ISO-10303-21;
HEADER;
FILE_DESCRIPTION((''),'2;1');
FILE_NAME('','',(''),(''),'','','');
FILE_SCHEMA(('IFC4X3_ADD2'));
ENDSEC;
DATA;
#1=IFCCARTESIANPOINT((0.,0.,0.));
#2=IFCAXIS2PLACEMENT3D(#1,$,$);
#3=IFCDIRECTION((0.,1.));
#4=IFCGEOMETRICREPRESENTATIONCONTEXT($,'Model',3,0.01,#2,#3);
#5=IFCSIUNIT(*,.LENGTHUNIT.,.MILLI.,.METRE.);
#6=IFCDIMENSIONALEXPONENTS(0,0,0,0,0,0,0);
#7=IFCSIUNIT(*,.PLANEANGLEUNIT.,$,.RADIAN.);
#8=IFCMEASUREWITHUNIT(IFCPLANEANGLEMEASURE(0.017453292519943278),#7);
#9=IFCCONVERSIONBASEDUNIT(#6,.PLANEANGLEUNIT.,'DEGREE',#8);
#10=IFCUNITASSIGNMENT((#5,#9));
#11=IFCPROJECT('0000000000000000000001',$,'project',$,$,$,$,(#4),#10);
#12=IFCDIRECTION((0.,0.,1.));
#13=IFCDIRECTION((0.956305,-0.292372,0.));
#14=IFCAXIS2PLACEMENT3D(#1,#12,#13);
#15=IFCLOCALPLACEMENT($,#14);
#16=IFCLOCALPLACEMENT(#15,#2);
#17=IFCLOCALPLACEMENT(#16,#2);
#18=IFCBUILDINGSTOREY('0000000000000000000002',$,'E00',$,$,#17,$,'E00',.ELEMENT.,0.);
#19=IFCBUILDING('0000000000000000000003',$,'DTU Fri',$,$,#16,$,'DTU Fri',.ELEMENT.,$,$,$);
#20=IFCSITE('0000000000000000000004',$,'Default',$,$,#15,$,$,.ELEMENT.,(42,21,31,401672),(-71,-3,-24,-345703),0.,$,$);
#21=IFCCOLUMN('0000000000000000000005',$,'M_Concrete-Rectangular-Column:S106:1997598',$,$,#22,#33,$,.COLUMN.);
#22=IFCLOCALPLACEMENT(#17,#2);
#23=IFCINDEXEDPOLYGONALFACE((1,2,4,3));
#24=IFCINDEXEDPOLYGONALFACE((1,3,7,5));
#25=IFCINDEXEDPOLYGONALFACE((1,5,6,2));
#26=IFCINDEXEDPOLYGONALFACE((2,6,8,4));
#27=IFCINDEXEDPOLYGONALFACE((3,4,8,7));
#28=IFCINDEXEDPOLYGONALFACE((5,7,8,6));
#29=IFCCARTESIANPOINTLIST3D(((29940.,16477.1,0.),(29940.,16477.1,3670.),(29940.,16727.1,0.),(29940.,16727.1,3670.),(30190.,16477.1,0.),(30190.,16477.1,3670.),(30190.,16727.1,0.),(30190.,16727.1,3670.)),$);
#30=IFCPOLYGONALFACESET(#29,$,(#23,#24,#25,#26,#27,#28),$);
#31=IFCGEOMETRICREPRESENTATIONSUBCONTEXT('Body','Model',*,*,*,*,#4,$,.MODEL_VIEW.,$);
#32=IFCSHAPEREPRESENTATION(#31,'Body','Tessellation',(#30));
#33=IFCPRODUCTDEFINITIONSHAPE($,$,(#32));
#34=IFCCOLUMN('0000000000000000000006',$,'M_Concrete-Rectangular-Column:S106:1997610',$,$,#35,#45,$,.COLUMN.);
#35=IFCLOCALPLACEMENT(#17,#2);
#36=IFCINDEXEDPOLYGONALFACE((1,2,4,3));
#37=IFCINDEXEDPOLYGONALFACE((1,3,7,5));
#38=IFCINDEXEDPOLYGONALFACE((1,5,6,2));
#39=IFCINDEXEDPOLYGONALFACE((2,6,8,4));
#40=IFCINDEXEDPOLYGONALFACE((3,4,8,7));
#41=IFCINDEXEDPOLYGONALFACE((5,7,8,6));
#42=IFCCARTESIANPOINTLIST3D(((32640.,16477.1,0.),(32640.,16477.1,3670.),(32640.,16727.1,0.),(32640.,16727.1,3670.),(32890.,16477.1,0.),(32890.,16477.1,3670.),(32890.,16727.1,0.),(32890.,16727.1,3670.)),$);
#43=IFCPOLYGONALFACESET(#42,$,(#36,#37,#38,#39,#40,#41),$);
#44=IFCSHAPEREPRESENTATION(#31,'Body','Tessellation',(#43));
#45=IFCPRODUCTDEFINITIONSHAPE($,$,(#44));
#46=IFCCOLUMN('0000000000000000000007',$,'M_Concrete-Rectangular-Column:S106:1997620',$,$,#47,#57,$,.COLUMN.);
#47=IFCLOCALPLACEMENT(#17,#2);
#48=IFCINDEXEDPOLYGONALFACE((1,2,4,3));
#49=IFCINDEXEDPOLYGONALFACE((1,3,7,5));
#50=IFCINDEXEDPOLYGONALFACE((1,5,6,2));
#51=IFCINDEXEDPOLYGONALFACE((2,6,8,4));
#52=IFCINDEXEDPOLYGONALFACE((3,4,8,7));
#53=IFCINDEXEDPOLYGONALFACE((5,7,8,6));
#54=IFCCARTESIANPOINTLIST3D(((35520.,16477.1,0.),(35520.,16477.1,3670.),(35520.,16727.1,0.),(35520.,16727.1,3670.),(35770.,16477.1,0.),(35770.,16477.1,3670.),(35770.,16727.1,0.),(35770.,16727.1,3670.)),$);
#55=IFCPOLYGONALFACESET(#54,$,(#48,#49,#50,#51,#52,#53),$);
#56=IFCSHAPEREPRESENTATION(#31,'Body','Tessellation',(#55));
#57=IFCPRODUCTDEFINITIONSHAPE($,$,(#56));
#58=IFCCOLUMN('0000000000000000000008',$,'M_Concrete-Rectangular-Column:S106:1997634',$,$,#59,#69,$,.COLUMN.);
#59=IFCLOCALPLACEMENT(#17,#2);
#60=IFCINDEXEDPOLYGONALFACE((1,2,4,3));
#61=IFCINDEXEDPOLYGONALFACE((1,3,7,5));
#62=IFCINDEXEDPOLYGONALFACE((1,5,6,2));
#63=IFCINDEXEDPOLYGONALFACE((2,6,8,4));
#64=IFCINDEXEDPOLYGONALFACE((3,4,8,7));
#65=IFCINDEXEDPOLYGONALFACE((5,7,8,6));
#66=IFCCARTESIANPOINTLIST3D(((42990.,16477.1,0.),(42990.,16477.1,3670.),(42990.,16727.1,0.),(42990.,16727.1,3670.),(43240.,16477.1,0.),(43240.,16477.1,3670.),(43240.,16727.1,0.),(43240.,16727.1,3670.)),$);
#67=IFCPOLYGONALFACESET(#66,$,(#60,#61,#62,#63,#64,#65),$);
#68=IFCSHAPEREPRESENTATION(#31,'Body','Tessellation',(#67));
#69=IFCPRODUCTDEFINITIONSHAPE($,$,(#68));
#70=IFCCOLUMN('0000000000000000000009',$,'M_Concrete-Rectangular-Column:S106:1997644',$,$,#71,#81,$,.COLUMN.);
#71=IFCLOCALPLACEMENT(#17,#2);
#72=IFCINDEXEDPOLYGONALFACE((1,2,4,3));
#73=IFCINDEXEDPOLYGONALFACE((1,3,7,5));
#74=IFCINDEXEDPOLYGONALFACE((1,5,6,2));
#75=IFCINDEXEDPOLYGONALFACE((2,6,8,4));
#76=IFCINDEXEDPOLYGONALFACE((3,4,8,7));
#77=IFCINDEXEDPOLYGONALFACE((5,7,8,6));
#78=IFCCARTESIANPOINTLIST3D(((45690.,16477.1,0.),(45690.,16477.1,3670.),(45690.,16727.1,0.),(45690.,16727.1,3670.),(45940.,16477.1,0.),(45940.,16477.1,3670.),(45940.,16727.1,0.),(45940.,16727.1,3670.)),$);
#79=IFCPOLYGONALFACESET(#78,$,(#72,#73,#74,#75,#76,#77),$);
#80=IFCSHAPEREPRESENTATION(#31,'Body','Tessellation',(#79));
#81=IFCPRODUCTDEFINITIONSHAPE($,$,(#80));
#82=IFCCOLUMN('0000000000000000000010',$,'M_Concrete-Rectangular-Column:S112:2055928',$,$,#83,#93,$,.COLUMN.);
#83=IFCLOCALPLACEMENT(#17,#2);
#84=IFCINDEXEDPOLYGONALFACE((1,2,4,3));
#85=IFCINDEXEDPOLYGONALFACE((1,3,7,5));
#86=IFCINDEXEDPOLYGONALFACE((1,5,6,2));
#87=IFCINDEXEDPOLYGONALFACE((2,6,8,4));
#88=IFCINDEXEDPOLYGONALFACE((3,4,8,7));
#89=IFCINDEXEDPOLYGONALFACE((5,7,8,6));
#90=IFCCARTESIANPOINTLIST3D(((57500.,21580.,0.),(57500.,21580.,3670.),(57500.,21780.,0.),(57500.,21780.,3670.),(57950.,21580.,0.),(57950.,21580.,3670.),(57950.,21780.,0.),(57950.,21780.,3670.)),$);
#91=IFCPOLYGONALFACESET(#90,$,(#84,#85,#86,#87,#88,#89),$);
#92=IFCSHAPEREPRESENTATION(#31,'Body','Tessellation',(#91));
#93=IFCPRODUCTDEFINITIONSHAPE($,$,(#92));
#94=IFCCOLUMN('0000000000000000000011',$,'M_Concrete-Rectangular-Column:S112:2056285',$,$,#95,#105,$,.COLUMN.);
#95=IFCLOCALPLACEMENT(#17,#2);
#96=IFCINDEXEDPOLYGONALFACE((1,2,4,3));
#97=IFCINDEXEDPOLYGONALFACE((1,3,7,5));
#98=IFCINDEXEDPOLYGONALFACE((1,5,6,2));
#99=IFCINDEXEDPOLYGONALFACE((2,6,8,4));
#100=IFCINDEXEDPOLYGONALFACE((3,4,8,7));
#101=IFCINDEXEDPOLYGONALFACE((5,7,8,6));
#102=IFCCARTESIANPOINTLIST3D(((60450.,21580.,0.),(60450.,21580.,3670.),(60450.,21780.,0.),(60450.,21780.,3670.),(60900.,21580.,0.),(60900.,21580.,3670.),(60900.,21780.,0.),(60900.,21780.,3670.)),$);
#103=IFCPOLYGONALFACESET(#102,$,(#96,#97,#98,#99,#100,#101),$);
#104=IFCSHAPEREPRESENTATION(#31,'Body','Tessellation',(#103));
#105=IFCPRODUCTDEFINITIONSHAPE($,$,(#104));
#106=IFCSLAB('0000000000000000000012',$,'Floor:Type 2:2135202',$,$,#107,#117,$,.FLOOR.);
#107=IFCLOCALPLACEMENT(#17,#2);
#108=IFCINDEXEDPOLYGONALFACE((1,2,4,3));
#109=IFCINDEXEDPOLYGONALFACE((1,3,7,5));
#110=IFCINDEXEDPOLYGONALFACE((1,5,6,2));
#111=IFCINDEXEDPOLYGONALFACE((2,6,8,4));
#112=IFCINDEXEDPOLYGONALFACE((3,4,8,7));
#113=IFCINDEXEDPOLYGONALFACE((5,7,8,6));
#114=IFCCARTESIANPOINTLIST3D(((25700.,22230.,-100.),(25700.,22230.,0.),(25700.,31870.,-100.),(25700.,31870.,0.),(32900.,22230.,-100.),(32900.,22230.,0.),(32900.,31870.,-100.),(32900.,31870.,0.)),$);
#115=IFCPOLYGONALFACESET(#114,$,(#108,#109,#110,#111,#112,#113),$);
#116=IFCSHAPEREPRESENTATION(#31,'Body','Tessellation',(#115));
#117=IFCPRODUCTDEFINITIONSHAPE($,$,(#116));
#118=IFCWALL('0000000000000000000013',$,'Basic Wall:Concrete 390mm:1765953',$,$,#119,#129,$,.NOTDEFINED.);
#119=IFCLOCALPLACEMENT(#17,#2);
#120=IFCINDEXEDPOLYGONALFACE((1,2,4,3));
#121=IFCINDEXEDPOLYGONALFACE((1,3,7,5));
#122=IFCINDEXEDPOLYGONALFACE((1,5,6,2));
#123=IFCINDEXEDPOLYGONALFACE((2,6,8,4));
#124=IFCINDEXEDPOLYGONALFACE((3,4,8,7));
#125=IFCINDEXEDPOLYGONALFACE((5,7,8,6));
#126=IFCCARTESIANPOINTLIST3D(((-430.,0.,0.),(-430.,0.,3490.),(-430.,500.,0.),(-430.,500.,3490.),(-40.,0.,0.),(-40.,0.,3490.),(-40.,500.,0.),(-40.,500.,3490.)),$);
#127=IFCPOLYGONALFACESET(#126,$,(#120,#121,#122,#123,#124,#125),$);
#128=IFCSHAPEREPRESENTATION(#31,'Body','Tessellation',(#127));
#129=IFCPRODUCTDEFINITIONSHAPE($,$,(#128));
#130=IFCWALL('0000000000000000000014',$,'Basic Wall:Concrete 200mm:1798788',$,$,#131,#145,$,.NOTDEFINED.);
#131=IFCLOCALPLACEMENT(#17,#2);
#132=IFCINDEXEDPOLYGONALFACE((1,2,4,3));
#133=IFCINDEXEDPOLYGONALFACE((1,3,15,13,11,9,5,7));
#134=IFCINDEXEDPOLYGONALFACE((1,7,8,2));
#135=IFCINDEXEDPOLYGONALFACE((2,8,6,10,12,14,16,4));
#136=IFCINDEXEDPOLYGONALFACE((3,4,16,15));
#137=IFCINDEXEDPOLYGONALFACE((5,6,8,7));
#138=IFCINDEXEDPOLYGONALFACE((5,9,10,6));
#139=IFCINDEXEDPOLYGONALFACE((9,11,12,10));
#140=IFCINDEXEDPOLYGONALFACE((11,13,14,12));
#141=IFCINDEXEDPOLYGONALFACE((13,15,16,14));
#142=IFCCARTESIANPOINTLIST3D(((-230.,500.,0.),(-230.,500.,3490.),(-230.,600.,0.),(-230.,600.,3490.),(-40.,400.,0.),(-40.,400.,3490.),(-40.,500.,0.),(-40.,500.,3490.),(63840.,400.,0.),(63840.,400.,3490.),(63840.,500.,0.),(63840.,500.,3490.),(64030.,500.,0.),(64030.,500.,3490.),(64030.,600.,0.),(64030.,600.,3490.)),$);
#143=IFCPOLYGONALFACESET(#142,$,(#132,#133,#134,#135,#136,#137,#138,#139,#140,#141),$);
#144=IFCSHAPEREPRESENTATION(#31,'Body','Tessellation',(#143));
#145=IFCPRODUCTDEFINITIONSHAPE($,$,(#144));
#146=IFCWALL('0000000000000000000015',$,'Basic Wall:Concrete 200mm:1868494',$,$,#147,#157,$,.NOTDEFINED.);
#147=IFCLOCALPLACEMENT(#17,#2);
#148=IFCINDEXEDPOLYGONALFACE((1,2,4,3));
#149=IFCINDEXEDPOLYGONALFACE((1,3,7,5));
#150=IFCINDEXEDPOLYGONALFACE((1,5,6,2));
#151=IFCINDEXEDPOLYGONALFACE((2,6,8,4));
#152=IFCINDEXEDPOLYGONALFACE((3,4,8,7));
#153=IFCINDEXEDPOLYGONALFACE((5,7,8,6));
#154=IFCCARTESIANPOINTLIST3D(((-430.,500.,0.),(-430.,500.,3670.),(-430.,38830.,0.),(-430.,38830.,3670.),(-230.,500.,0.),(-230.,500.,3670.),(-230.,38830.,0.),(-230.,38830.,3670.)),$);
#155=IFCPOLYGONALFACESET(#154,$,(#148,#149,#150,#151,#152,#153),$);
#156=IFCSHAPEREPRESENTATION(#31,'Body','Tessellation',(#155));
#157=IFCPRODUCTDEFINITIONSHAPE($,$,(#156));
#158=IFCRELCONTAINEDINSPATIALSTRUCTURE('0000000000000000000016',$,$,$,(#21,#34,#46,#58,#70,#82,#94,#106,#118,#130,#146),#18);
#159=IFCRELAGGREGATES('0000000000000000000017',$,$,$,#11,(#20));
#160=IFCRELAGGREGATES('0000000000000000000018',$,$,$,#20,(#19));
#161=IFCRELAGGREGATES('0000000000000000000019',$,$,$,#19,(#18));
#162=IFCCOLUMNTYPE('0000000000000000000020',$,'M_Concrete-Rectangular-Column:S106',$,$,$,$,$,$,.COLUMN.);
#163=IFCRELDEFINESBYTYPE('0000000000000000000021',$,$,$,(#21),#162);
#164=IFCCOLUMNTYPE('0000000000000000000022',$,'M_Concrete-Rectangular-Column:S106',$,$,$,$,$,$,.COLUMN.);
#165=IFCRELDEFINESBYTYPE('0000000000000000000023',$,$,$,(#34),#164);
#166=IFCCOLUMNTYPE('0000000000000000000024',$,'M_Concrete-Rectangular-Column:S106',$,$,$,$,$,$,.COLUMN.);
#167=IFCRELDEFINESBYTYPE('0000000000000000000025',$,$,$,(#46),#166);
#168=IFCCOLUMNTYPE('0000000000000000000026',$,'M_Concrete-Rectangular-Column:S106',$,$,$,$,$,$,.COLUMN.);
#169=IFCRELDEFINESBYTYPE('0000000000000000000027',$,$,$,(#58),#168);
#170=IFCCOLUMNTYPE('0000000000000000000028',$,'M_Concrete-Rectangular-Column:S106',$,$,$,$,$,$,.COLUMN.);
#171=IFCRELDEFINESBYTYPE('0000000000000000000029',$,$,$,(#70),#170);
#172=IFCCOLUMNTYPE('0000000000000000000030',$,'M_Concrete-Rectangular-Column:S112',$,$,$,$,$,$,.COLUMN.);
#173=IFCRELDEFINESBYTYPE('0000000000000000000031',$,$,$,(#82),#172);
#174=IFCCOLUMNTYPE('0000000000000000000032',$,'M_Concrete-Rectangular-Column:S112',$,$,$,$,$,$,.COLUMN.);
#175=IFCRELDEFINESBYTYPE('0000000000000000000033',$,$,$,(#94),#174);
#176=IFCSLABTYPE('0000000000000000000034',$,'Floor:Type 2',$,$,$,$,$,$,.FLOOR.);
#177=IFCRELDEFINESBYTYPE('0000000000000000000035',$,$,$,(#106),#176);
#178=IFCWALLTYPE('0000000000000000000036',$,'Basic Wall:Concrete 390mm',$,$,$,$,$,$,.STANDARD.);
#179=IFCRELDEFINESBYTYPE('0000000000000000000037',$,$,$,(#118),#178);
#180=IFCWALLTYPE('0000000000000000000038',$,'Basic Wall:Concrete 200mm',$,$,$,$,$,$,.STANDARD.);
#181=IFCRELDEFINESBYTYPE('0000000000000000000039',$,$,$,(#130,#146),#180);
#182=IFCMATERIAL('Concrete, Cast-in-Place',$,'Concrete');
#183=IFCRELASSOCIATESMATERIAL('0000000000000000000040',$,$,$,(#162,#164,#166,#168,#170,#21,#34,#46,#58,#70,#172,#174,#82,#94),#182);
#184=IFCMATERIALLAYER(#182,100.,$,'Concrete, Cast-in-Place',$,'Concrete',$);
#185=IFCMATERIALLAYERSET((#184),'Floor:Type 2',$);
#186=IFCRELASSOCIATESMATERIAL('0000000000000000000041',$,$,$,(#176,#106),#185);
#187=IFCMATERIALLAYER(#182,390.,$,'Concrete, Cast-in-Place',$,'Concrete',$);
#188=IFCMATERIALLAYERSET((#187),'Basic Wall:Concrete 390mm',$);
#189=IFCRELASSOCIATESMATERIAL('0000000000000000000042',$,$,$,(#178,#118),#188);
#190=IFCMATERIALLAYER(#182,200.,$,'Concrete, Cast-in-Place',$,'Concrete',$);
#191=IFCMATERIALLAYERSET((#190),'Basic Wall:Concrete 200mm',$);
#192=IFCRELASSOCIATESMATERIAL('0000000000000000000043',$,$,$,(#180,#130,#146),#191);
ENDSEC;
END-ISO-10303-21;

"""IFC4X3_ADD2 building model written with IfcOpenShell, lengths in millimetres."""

from ifc_helpers import new_model, entity, si_unit, converted_unit, direction, frame, frame_2d, origin, origin_2d_with_axis, place, context, subcontext, project, spatial, polyline, rectangle, outline, extrude, source, transform, mapped, material, layer, layer_set, layer_usage, material_profile, profile_set, profile_usage, type_object, type_shapes, element, save


model = new_model("IFC4X3_ADD2")

# Units and contexts
model_context = context("Model", 3, precision=0.01, world=origin(), true_north=direction((0.0, 1.0)))
body_context = subcontext(model_context, "Body", "Model", "MODEL_VIEW")
ifc_project = project(units=[si_unit("LENGTHUNIT", "METRE", prefix="MILLI"), converted_unit("PLANEANGLEUNIT", "DEGREE", entity("IfcPlaneAngleMeasure", 0.017453292519943278), si_unit("PLANEANGLEUNIT", "RADIAN"), dimensions=[0, 0, 0, 0, 0, 0, 0])], contexts=[model_context])

# Site, building, storey
site_placement = place(None, frame((0.0, 0.0, 0.0), z_axis=(0.0, 0.0, 1.0), x_axis=(0.956305, -0.292372, 0.0)))
site = spatial("IfcSite", under=ifc_project, at=site_placement, Name="Default", CompositionType="ELEMENT", RefLatitude=(42, 21, 31, 401672), RefLongitude=(-71, -3, -24, -345703), RefElevation=0.0)
building_placement = place(site_placement, origin())
building = spatial("IfcBuilding", under=site, at=building_placement, Name="DTU Fri", LongName="DTU Fri", CompositionType="ELEMENT")
storey_placement = place(building_placement, origin())
storey = spatial("IfcBuildingStorey", under=building, at=storey_placement, Name="E00", LongName="E00", CompositionType="ELEMENT", Elevation=0.0)

# Columns
ifc_material = material(Name="Concrete, Cast-in-Place", Category="Concrete")
ifc_material_profile_1 = material_profile(ifc_material, rectangle(XDim=250.0, YDim=250.0, at=frame_2d((0.0, 0.0), x_axis=(1.0, 0.0))), Name="S106")
ifc_profile_set_1 = profile_set([ifc_material_profile_1], Name="S106")
ifc_profile_usage_1 = profile_usage(ifc_profile_set_1)
column_type_1 = type_object("IfcColumnType", Name="M_Concrete-Rectangular-Column:S106", PredefinedType="COLUMN", material=ifc_profile_set_1)
shared_shape_1 = source(origin(), body_context, "Body", "SweptSolid", [
    extrude(rectangle(XDim=250.0, YDim=250.0, at=origin_2d_with_axis()), frame((30065.0, 16602.1, 0.0), z_axis=(0.0, 0.0, 1.0), x_axis=(0.0, 1.0, 0.0)), (0.0, 0.0, 1.0), 3670.0),
])
type_shapes(column_type_1, [shared_shape_1])
column_1_placement = place(storey_placement, origin())
element("IfcColumn", 1, at=column_1_placement, inside=storey, type_object=column_type_1, material=ifc_profile_usage_1, Name="M_Concrete-Rectangular-Column:S106:1997598", PredefinedType="COLUMN", context=body_context, shape_type="MappedRepresentation", body=[
    mapped(shared_shape_1, transform((0.0, 0.0, 0.0), scale=1.0)),
])
column_type_2 = type_object("IfcColumnType", Name="M_Concrete-Rectangular-Column:S106", PredefinedType="COLUMN", material=ifc_profile_set_1)
shared_shape_2 = source(origin(), body_context, "Body", "SweptSolid", [
    extrude(rectangle(XDim=250.0, YDim=250.0, at=frame_2d((0.0, 0.0), x_axis=(1.0, 0.0))), frame((32765.0, 16602.1, 0.0), z_axis=(0.0, 0.0, 1.0), x_axis=(0.0, 1.0, 0.0)), (0.0, 0.0, 1.0), 3670.0),
])
type_shapes(column_type_2, [shared_shape_2])
column_2_placement = place(storey_placement, origin())
element("IfcColumn", 2, at=column_2_placement, inside=storey, type_object=column_type_2, material=ifc_profile_usage_1, Name="M_Concrete-Rectangular-Column:S106:1997610", PredefinedType="COLUMN", context=body_context, shape_type="MappedRepresentation", body=[
    mapped(shared_shape_2, transform((0.0, 0.0, 0.0), scale=1.0)),
])
column_type_3 = type_object("IfcColumnType", Name="M_Concrete-Rectangular-Column:S106", PredefinedType="COLUMN", material=ifc_profile_set_1)
shared_shape_3 = source(origin(), body_context, "Body", "SweptSolid", [
    extrude(rectangle(XDim=250.0, YDim=250.0, at=origin_2d_with_axis()), frame((35645.0, 16602.1, 0.0), z_axis=(0.0, 0.0, 1.0), x_axis=(0.0, 1.0, 0.0)), (0.0, 0.0, 1.0), 3670.0),
])
type_shapes(column_type_3, [shared_shape_3])
column_3_placement = place(storey_placement, origin())
element("IfcColumn", 3, at=column_3_placement, inside=storey, type_object=column_type_3, material=ifc_profile_usage_1, Name="M_Concrete-Rectangular-Column:S106:1997620", PredefinedType="COLUMN", context=body_context, shape_type="MappedRepresentation", body=[
    mapped(shared_shape_3, transform((0.0, 0.0, 0.0), scale=1.0)),
])
column_type_4 = type_object("IfcColumnType", Name="M_Concrete-Rectangular-Column:S106", PredefinedType="COLUMN", material=ifc_profile_set_1)
shared_shape_4 = source(origin(), body_context, "Body", "SweptSolid", [
    extrude(rectangle(XDim=250.0, YDim=250.0, at=frame_2d((0.0, 0.0), x_axis=(1.0, 0.0))), frame((43115.0, 16602.1, 0.0), z_axis=(0.0, 0.0, 1.0), x_axis=(0.0, 1.0, 0.0)), (0.0, 0.0, 1.0), 3670.0),
])
type_shapes(column_type_4, [shared_shape_4])
column_4_placement = place(storey_placement, origin())
element("IfcColumn", 4, at=column_4_placement, inside=storey, type_object=column_type_4, material=ifc_profile_usage_1, Name="M_Concrete-Rectangular-Column:S106:1997634", PredefinedType="COLUMN", context=body_context, shape_type="MappedRepresentation", body=[
    mapped(shared_shape_4, transform((0.0, 0.0, 0.0), scale=1.0)),
])
column_type_5 = type_object("IfcColumnType", Name="M_Concrete-Rectangular-Column:S106", PredefinedType="COLUMN", material=ifc_profile_set_1)
shared_shape_5 = source(origin(), body_context, "Body", "SweptSolid", [
    extrude(rectangle(XDim=250.0, YDim=250.0, at=frame_2d((0.0, 0.0), x_axis=(1.0, 0.0))), frame((45815.0, 16602.1, 0.0), z_axis=(0.0, 0.0, 1.0), x_axis=(0.0, 1.0, 0.0)), (0.0, 0.0, 1.0), 3670.0),
])
type_shapes(column_type_5, [shared_shape_5])
column_5_placement = place(storey_placement, origin())
element("IfcColumn", 5, at=column_5_placement, inside=storey, type_object=column_type_5, material=ifc_profile_usage_1, Name="M_Concrete-Rectangular-Column:S106:1997644", PredefinedType="COLUMN", context=body_context, shape_type="MappedRepresentation", body=[
    mapped(shared_shape_5, transform((0.0, 0.0, 0.0), scale=1.0)),
])
ifc_material_profile_2 = material_profile(ifc_material, rectangle(XDim=200.0, YDim=450.0, at=origin_2d_with_axis()), Name="S112")
ifc_profile_set_2 = profile_set([ifc_material_profile_2], Name="S112")
ifc_profile_usage_2 = profile_usage(ifc_profile_set_2)
column_type_6 = type_object("IfcColumnType", Name="M_Concrete-Rectangular-Column:S112", PredefinedType="COLUMN", material=ifc_profile_set_2)
shared_shape_6 = source(origin(), body_context, "Body", "SweptSolid", [
    extrude(rectangle(XDim=200.0, YDim=450.0, at=origin_2d_with_axis()), frame((57725.0, 21680.0, 0.0), z_axis=(0.0, 0.0, 1.0), x_axis=(0.0, 1.0, 0.0)), (0.0, 0.0, 1.0), 3670.0),
])
type_shapes(column_type_6, [shared_shape_6])
column_6_placement = place(storey_placement, origin())
element("IfcColumn", 6, at=column_6_placement, inside=storey, type_object=column_type_6, material=ifc_profile_usage_2, Name="M_Concrete-Rectangular-Column:S112:2055928", PredefinedType="COLUMN", context=body_context, shape_type="MappedRepresentation", body=[
    mapped(shared_shape_6, transform((0.0, 0.0, 0.0), scale=1.0)),
])
column_type_7 = type_object("IfcColumnType", Name="M_Concrete-Rectangular-Column:S112", PredefinedType="COLUMN", material=ifc_profile_set_2)
shared_shape_7 = source(origin(), body_context, "Body", "SweptSolid", [
    extrude(rectangle(XDim=200.0, YDim=450.0, at=origin_2d_with_axis()), frame((60675.0, 21680.0, 0.0), z_axis=(0.0, 0.0, 1.0), x_axis=(0.0, 1.0, 0.0)), (0.0, 0.0, 1.0), 3670.0),
])
type_shapes(column_type_7, [shared_shape_7])
column_7_placement = place(storey_placement, origin())
element("IfcColumn", 7, at=column_7_placement, inside=storey, type_object=column_type_7, material=ifc_profile_usage_2, Name="M_Concrete-Rectangular-Column:S112:2056285", PredefinedType="COLUMN", context=body_context, shape_type="MappedRepresentation", body=[
    mapped(shared_shape_7, transform((0.0, 0.0, 0.0), scale=1.0)),
])

# Slab
ifc_layer_1 = layer(ifc_material, 100.0, Name="Concrete, Cast-in-Place", Category="Concrete")
ifc_layer_set_1 = layer_set([ifc_layer_1], Name="Floor:Type 2")
slab_type_1 = type_object("IfcSlabType", Name="Floor:Type 2", PredefinedType="FLOOR", material=ifc_layer_set_1)
ifc_layer_usage_1 = layer_usage(ifc_layer_set_1, "AXIS3", "POSITIVE", 0.0)
slab_1_placement = place(storey_placement, origin())
element("IfcSlab", 8, at=slab_1_placement, inside=storey, type_object=slab_type_1, material=ifc_layer_usage_1, Name="Floor:Type 2:2135202", PredefinedType="FLOOR", context=body_context, shape_type="SweptSolid", body=[
    extrude(rectangle(XDim=9640.0, YDim=7200.0, at=frame_2d((0.0, 0.0), x_axis=(1.0, 0.0))), frame((29300.0, 27050.0, 0.0), z_axis=(0.0, 0.0, -1.0), x_axis=(0.0, 1.0, 0.0)), (0.0, 0.0, 1.0), 100.0),
])

# Walls
ifc_layer_2 = layer(ifc_material, 390.0, Name="Concrete, Cast-in-Place", Category="Concrete")
ifc_layer_set_2 = layer_set([ifc_layer_2], Name="Basic Wall:Concrete 390mm")
wall_type_1 = type_object("IfcWallType", Name="Basic Wall:Concrete 390mm", PredefinedType="STANDARD", material=ifc_layer_set_2)
wall_1_placement = place(storey_placement, frame((-235.0, 0.0, 0.0), z_axis=(0.0, 0.0, 1.0), x_axis=(0.0, 1.0, 0.0)))
element("IfcWall", 9, at=wall_1_placement, inside=storey, type_object=wall_type_1, material=ifc_layer_set_2, Name="Basic Wall:Concrete 390mm:1765953", PredefinedType="NOTDEFINED", context=body_context, shape_type="SweptSolid", body=[
    extrude(rectangle(XDim=500.0, YDim=390.0, at=frame_2d((250.0, 0.0), x_axis=(-1.0, 0.0))), origin(), (0.0, 0.0, 1.0), 3490.0),
])
ifc_layer_3 = layer(ifc_material, 200.0, Name="Concrete, Cast-in-Place", Category="Concrete")
ifc_layer_set_3 = layer_set([ifc_layer_3], Name="Basic Wall:Concrete 200mm")
wall_type_2 = type_object("IfcWallType", Name="Basic Wall:Concrete 200mm", PredefinedType="STANDARD", material=ifc_layer_set_3)
wall_2_placement = place(storey_placement, frame((-230.0, 500.0, 0.0)))
element("IfcWall", 10, at=wall_2_placement, inside=storey, type_object=wall_type_2, material=ifc_layer_set_3, Name="Basic Wall:Concrete 200mm:1798788", PredefinedType="NOTDEFINED", context=body_context, shape_type="SweptSolid", body=[
    extrude(outline(polyline([(-100.0, 31940.0), (-100.0, -31940.0), (0.0, -31940.0), (0.0, -32130.0), (100.0, -32130.0), (100.0, 32130.0), (0.0, 32130.0), (0.0, 31940.0), (-100.0, 31940.0)])), frame((32130.0, 0.0, 0.0), z_axis=(0.0, 0.0, -1.0), x_axis=(0.0, 1.0, 0.0)), (0.0, 0.0, -1.0), 3490.0),
])
wall_3_placement = place(storey_placement, frame((-330.0, 500.0, 0.0), z_axis=(0.0, 0.0, 1.0), x_axis=(0.0, 1.0, 0.0)))
element("IfcWall", 11, at=wall_3_placement, inside=storey, type_object=wall_type_2, material=ifc_layer_set_3, Name="Basic Wall:Concrete 200mm:1868494", PredefinedType="NOTDEFINED", context=body_context, shape_type="SweptSolid", body=[
    extrude(rectangle(XDim=38330.0, YDim=200.0, at=frame_2d((19165.0, 0.0), x_axis=(-1.0, 0.0))), origin(), (0.0, 0.0, 1.0), 3670.0),
])

save(model, "model.ifc")
